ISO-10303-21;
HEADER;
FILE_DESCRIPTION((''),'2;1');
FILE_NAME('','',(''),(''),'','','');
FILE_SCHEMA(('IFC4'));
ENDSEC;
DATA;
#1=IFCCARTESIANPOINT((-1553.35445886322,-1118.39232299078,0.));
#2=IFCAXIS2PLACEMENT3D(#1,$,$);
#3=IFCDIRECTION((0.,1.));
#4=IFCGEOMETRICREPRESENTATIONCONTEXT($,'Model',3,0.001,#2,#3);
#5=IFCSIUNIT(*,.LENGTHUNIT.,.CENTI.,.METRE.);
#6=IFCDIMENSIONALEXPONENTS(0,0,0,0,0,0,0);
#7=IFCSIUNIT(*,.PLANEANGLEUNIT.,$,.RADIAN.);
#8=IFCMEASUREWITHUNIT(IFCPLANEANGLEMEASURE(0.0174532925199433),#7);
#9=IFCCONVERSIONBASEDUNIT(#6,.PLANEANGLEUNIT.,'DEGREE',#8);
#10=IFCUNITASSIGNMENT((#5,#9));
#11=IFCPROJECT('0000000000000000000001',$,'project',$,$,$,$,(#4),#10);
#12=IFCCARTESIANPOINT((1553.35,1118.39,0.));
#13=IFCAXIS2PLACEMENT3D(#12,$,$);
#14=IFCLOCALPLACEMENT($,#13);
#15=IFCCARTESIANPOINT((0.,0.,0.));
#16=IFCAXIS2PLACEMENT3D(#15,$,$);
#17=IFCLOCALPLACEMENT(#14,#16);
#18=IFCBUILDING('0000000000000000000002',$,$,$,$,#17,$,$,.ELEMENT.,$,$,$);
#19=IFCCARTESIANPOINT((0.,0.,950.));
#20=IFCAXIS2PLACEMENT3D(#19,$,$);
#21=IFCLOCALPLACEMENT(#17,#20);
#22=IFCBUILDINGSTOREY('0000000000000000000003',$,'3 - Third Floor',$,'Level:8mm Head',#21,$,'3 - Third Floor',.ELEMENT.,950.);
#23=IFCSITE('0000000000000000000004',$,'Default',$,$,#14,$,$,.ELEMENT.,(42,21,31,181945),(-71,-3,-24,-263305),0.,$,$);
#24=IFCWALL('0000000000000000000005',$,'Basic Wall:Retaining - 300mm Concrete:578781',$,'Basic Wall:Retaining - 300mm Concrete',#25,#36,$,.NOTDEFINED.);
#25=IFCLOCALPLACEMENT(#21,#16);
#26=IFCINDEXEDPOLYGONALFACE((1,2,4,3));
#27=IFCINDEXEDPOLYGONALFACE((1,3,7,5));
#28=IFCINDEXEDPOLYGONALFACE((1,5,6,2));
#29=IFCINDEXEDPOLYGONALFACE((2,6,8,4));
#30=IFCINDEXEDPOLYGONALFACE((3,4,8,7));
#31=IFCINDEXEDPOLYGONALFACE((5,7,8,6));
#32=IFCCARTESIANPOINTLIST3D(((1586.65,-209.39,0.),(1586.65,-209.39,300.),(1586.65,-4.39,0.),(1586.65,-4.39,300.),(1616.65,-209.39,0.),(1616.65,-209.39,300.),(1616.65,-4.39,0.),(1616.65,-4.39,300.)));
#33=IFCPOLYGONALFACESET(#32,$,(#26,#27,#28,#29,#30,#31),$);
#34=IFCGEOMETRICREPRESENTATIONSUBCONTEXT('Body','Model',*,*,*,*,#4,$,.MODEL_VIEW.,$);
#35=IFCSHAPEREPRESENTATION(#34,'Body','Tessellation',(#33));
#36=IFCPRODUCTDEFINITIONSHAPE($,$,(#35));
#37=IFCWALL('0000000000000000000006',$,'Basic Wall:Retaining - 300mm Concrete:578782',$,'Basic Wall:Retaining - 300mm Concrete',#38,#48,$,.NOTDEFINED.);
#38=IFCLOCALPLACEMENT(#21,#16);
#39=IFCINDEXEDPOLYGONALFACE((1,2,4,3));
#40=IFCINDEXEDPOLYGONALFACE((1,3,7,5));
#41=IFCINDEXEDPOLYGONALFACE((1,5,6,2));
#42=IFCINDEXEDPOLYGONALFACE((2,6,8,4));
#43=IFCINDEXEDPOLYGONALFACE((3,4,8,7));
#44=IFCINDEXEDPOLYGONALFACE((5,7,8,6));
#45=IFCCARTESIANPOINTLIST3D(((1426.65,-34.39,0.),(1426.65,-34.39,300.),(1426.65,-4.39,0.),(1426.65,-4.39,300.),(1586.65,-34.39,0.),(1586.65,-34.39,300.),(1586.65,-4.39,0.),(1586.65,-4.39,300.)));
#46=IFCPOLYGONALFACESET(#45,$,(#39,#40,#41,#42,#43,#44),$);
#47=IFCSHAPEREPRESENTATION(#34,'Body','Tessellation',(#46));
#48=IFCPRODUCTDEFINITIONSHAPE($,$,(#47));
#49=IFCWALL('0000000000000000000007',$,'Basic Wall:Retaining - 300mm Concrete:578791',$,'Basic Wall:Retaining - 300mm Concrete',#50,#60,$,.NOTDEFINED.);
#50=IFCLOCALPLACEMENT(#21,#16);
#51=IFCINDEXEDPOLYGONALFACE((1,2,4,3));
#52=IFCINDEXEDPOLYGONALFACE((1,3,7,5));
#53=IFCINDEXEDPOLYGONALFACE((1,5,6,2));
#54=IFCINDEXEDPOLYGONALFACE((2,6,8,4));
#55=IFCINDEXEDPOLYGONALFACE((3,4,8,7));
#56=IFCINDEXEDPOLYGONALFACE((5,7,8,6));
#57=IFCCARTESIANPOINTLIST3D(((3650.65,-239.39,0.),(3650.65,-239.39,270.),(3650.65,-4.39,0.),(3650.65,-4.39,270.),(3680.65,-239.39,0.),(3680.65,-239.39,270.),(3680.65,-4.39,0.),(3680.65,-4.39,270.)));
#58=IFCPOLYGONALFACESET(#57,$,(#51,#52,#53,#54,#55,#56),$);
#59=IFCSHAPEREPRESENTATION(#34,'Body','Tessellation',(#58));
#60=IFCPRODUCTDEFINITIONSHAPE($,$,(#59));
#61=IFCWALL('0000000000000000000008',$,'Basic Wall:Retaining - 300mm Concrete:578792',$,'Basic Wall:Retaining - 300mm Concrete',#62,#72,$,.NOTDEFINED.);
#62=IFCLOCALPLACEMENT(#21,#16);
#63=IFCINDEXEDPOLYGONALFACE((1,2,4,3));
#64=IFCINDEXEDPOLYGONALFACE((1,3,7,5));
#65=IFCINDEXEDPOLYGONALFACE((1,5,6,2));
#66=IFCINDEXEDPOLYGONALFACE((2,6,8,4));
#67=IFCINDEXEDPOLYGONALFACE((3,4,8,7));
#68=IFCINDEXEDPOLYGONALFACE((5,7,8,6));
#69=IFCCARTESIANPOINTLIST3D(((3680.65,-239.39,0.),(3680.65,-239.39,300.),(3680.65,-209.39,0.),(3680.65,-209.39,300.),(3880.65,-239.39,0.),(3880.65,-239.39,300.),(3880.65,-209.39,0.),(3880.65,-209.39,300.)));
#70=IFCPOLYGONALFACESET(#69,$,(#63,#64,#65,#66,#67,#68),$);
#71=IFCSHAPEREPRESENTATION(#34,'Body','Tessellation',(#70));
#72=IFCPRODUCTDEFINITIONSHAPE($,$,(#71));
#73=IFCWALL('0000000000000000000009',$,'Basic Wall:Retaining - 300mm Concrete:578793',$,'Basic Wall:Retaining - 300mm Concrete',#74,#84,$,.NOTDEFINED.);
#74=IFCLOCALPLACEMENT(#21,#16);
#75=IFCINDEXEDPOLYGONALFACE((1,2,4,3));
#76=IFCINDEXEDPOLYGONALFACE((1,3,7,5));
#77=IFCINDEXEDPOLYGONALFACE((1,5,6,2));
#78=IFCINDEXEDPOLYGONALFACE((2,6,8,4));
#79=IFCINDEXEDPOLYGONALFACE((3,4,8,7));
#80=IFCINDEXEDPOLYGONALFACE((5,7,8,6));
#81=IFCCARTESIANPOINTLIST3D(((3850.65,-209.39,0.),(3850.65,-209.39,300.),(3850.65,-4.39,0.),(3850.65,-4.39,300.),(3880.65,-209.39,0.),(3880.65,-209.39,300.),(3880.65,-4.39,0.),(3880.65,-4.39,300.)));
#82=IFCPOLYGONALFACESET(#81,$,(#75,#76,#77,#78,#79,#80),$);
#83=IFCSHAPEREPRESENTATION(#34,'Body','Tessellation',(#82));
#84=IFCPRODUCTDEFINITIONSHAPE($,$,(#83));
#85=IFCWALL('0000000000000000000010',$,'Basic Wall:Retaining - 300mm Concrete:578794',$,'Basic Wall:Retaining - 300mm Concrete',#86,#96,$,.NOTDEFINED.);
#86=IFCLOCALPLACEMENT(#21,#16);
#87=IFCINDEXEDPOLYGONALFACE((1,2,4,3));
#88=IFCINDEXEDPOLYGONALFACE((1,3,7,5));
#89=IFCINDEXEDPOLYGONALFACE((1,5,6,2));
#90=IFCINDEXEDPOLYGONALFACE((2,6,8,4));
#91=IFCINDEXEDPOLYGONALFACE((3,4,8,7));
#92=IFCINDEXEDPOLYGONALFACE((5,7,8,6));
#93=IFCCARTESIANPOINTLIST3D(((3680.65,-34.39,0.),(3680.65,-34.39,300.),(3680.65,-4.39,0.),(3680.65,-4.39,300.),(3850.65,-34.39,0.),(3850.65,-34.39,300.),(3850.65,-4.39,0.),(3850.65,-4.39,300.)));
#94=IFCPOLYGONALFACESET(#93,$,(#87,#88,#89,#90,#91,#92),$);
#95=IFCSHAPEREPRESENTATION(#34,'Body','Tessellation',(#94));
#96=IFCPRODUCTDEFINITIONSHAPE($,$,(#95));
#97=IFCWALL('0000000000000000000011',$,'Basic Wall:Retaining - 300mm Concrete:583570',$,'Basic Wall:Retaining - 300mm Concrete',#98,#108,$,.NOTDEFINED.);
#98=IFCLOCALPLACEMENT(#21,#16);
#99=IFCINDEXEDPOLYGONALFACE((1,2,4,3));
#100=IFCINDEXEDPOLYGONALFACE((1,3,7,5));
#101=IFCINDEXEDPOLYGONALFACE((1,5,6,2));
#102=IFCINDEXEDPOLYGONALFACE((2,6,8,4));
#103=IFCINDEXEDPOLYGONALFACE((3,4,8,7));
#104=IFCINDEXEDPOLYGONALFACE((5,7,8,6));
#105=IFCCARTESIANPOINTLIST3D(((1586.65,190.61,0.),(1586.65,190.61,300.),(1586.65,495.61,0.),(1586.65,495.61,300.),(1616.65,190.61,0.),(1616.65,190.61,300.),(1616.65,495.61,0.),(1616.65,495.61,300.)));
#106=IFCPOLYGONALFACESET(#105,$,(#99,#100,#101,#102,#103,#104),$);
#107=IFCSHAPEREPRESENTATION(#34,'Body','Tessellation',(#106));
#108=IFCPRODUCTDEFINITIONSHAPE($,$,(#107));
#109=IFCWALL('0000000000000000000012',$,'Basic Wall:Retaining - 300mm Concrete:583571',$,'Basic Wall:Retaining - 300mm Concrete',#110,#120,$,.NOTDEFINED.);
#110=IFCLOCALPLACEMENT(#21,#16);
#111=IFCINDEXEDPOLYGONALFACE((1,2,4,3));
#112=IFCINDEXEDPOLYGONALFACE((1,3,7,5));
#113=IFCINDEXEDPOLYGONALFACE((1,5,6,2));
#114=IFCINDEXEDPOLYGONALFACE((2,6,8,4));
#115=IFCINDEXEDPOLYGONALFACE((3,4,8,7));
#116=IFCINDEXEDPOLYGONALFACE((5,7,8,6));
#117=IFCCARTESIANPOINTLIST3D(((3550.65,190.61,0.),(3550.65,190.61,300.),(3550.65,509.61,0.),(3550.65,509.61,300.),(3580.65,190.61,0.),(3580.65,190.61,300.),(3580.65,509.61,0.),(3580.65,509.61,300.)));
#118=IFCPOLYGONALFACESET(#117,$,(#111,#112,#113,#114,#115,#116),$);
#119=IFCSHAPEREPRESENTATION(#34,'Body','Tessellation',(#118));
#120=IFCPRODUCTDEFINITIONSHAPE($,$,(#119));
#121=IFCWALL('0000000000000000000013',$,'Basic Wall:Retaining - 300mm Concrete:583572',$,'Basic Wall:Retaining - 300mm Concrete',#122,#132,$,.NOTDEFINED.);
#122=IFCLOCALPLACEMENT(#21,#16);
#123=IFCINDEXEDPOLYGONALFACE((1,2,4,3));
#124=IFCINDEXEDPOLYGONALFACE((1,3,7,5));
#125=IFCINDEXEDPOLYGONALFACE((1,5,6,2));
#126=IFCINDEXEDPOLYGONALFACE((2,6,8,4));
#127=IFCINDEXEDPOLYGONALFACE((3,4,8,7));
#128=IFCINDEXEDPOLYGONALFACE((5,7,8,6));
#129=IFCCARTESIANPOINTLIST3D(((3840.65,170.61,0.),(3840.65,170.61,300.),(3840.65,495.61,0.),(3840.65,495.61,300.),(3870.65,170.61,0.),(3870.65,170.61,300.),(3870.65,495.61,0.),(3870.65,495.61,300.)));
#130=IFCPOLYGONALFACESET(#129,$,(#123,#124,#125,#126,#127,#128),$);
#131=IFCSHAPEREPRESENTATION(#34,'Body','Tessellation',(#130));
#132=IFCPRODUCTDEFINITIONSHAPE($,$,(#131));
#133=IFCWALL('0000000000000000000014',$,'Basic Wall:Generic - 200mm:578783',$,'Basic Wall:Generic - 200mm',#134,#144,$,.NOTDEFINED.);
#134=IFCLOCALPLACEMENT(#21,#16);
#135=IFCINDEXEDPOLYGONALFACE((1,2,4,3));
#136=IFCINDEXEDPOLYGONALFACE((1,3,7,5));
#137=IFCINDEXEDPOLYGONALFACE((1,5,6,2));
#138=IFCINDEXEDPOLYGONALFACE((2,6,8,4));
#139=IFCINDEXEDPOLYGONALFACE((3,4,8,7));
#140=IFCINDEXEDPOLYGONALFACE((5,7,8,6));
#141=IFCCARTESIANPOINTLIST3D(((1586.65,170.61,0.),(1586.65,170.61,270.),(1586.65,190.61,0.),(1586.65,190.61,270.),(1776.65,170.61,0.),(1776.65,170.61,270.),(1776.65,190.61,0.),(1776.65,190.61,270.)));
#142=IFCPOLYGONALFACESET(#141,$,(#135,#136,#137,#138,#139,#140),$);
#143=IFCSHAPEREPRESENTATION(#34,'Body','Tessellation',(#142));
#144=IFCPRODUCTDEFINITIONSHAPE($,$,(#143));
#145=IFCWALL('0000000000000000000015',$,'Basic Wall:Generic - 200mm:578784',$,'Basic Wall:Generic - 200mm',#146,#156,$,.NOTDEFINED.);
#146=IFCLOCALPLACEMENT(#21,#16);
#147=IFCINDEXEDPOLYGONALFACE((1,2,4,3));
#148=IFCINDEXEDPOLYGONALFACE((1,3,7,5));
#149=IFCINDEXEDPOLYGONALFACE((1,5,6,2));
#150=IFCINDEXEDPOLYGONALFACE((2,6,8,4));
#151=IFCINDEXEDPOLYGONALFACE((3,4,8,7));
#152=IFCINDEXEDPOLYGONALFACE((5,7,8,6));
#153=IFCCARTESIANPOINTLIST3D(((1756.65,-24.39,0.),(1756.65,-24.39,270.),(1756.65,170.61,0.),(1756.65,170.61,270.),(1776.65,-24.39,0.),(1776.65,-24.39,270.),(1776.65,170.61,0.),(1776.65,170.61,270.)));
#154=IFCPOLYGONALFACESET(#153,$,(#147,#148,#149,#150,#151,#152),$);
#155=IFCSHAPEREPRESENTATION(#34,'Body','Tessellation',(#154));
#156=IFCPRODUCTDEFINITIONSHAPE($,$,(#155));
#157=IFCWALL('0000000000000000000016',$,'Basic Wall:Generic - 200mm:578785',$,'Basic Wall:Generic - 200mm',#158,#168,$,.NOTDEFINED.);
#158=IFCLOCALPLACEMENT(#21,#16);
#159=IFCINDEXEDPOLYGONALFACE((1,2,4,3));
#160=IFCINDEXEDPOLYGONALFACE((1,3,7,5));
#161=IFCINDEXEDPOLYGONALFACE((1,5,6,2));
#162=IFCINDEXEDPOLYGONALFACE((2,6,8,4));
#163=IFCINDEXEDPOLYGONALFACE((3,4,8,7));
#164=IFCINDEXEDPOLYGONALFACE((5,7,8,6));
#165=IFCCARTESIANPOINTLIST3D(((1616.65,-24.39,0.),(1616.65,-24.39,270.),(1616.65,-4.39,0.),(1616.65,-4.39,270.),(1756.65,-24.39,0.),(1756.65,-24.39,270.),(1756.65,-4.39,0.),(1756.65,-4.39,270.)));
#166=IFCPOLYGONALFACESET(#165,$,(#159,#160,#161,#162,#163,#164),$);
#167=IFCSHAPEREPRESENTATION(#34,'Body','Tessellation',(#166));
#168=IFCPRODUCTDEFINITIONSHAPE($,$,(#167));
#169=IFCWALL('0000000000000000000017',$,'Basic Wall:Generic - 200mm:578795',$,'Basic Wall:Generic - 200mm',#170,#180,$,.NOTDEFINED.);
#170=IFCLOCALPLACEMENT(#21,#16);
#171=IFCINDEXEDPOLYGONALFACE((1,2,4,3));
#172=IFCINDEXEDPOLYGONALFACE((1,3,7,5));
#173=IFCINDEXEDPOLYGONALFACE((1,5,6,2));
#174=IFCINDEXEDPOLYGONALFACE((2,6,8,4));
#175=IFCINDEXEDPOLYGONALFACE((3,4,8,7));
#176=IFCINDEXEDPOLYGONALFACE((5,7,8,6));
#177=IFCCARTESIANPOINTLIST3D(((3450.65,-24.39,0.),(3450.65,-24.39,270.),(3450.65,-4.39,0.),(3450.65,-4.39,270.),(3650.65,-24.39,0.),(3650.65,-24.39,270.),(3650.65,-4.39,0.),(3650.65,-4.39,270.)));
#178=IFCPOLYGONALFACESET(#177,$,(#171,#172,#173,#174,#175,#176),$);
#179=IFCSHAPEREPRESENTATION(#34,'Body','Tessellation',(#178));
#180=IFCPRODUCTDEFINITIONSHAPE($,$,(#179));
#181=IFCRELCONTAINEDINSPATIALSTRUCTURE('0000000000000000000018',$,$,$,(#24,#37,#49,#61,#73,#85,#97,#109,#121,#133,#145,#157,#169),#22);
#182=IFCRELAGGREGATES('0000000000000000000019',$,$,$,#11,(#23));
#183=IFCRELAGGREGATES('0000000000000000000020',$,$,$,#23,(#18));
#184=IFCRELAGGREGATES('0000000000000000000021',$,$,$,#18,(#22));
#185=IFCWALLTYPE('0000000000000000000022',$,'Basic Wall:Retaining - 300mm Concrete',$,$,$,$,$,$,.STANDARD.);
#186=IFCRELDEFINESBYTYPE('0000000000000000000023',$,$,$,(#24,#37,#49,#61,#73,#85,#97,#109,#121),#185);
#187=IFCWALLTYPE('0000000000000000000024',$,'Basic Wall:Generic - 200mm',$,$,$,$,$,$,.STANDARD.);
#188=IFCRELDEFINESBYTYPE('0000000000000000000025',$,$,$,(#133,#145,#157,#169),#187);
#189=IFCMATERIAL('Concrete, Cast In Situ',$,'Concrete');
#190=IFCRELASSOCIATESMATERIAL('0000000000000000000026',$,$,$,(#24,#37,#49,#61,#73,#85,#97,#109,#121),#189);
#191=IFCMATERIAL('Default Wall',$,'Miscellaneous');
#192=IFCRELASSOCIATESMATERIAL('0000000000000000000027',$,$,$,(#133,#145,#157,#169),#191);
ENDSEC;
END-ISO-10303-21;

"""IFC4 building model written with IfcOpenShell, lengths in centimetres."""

from ifc_helpers import new_model, entity, si_unit, converted_unit, direction, frame, origin, place, context, subcontext, project, spatial, indexed_curve, outline, extrude, material, type_object, element, save


model = new_model("IFC4")

# Units and contexts
model_context = context("Model", 3, precision=0.001, world=frame((-1553.35445886322, -1118.39232299078, 0.0)), true_north=direction((0.0, 1.0)))
body_context = subcontext(model_context, "Body", "Model", "MODEL_VIEW")
ifc_project = project(units=[si_unit("LENGTHUNIT", "METRE", prefix="CENTI"), converted_unit("PLANEANGLEUNIT", "DEGREE", entity("IfcPlaneAngleMeasure", 0.0174532925199433), si_unit("PLANEANGLEUNIT", "RADIAN"), dimensions=[0, 0, 0, 0, 0, 0, 0])], contexts=[model_context])

# Site, building, storey
site_placement = place(None, frame((1553.35, 1118.39, 0.0)))
site = spatial("IfcSite", under=ifc_project, at=site_placement, Name="Default", CompositionType="ELEMENT", RefLatitude=(42, 21, 31, 181945), RefLongitude=(-71, -3, -24, -263305), RefElevation=0.0)
building_placement = place(site_placement, origin())
building = spatial("IfcBuilding", under=site, at=building_placement, CompositionType="ELEMENT")
storey_placement = place(building_placement, frame((0.0, 0.0, 950.0)))
storey = spatial("IfcBuildingStorey", under=building, at=storey_placement, Name="3 - Third Floor", ObjectType="Level:8mm Head", LongName="3 - Third Floor", CompositionType="ELEMENT", Elevation=950.0)

# Walls
ifc_material_1 = material(Name="Concrete, Cast In Situ", Category="Concrete")
wall_type_1 = type_object("IfcWallType", Name="Basic Wall:Retaining - 300mm Concrete", PredefinedType="STANDARD")
wall_1_placement = place(storey_placement, frame((1601.65, -209.39, 0.0), z_axis=(0.0, 0.0, 1.0), x_axis=(0.0, 1.0, 0.0)))
element("IfcWall", 1, at=wall_1_placement, inside=storey, type_object=wall_type_1, material=ifc_material_1, Name="Basic Wall:Retaining - 300mm Concrete:578781", ObjectType="Basic Wall:Retaining - 300mm Concrete", PredefinedType="NOTDEFINED", context=body_context, shape_type="SweptSolid", body=[
    extrude(outline(indexed_curve([(205.0, 15.0), (0.0, 15.0), (0.0, -15.0), (205.0, -15.0), (205.0, 15.0)], self_intersect=False)), origin(), (0.0, 0.0, 1.0), 300.0),
])
wall_2_placement = place(storey_placement, frame((1586.65, -19.39, 0.0), z_axis=(0.0, 0.0, 1.0), x_axis=(-1.0, 0.0, 0.0)))
element("IfcWall", 2, at=wall_2_placement, inside=storey, type_object=wall_type_1, material=ifc_material_1, Name="Basic Wall:Retaining - 300mm Concrete:578782", ObjectType="Basic Wall:Retaining - 300mm Concrete", PredefinedType="NOTDEFINED", context=body_context, shape_type="SweptSolid", body=[
    extrude(outline(indexed_curve([(160.0, 15.0), (0.0, 15.0), (0.0, -15.0), (160.0, -15.0), (160.0, 15.0)], self_intersect=False)), origin(), (0.0, 0.0, 1.0), 300.0),
])
wall_3_placement = place(storey_placement, frame((3665.65, -4.39, 0.0), z_axis=(0.0, 0.0, 1.0), x_axis=(0.0, -1.0, 0.0)))
element("IfcWall", 3, at=wall_3_placement, inside=storey, type_object=wall_type_1, material=ifc_material_1, Name="Basic Wall:Retaining - 300mm Concrete:578791", ObjectType="Basic Wall:Retaining - 300mm Concrete", PredefinedType="NOTDEFINED", context=body_context, shape_type="SweptSolid", body=[
    extrude(outline(indexed_curve([(235.0, 15.0), (0.0, 15.0), (0.0, -15.0), (235.0, -15.0), (235.0, 15.0)], self_intersect=False)), origin(), (0.0, 0.0, 1.0), 270.0),
])
wall_4_placement = place(storey_placement, frame((3680.65, -224.39, 0.0)))
element("IfcWall", 4, at=wall_4_placement, inside=storey, type_object=wall_type_1, material=ifc_material_1, Name="Basic Wall:Retaining - 300mm Concrete:578792", ObjectType="Basic Wall:Retaining - 300mm Concrete", PredefinedType="NOTDEFINED", context=body_context, shape_type="SweptSolid", body=[
    extrude(outline(indexed_curve([(200.0, 15.0), (0.0, 15.0), (0.0, -15.0), (200.0, -15.0), (200.0, 15.0)], self_intersect=False)), origin(), (0.0, 0.0, 1.0), 300.0),
])
wall_5_placement = place(storey_placement, frame((3865.65, -209.39, 0.0), z_axis=(0.0, 0.0, 1.0), x_axis=(0.0, 1.0, 0.0)))
element("IfcWall", 5, at=wall_5_placement, inside=storey, type_object=wall_type_1, material=ifc_material_1, Name="Basic Wall:Retaining - 300mm Concrete:578793", ObjectType="Basic Wall:Retaining - 300mm Concrete", PredefinedType="NOTDEFINED", context=body_context, shape_type="SweptSolid", body=[
    extrude(outline(indexed_curve([(205.0, 15.0), (0.0, 15.0), (0.0, -15.0), (205.0, -15.0), (205.0, 15.0)], self_intersect=False)), origin(), (0.0, 0.0, 1.0), 300.0),
])
wall_6_placement = place(storey_placement, frame((3850.65, -19.39, 0.0), z_axis=(0.0, 0.0, 1.0), x_axis=(-1.0, 0.0, 0.0)))
element("IfcWall", 6, at=wall_6_placement, inside=storey, type_object=wall_type_1, material=ifc_material_1, Name="Basic Wall:Retaining - 300mm Concrete:578794", ObjectType="Basic Wall:Retaining - 300mm Concrete", PredefinedType="NOTDEFINED", context=body_context, shape_type="SweptSolid", body=[
    extrude(outline(indexed_curve([(170.0, 15.0), (0.0, 15.0), (0.0, -15.0), (170.0, -15.0), (170.0, 15.0)], self_intersect=False)), origin(), (0.0, 0.0, 1.0), 300.0),
])
wall_7_placement = place(storey_placement, frame((1601.65, 495.61, 0.0), z_axis=(0.0, 0.0, 1.0), x_axis=(0.0, -1.0, 0.0)))
element("IfcWall", 7, at=wall_7_placement, inside=storey, type_object=wall_type_1, material=ifc_material_1, Name="Basic Wall:Retaining - 300mm Concrete:583570", ObjectType="Basic Wall:Retaining - 300mm Concrete", PredefinedType="NOTDEFINED", context=body_context, shape_type="SweptSolid", body=[
    extrude(outline(indexed_curve([(305.0, 15.0), (0.0, 15.0), (0.0, -15.0), (305.0, -15.0), (305.0, 15.0)], self_intersect=False)), origin(), (0.0, 0.0, 1.0), 300.0),
])
wall_8_placement = place(storey_placement, frame((3565.65, 509.61, 0.0), z_axis=(0.0, 0.0, 1.0), x_axis=(0.0, -1.0, 0.0)))
element("IfcWall", 8, at=wall_8_placement, inside=storey, type_object=wall_type_1, material=ifc_material_1, Name="Basic Wall:Retaining - 300mm Concrete:583571", ObjectType="Basic Wall:Retaining - 300mm Concrete", PredefinedType="NOTDEFINED", context=body_context, shape_type="SweptSolid", body=[
    extrude(outline(indexed_curve([(319.0, 15.0), (0.0, 15.0), (0.0, -15.0), (319.0, -15.0), (319.0, 15.0)], self_intersect=False)), origin(), (0.0, 0.0, 1.0), 300.0),
])
wall_9_placement = place(storey_placement, frame((3855.65, 495.61, 0.0), z_axis=(0.0, 0.0, 1.0), x_axis=(0.0, -1.0, 0.0)))
element("IfcWall", 9, at=wall_9_placement, inside=storey, type_object=wall_type_1, material=ifc_material_1, Name="Basic Wall:Retaining - 300mm Concrete:583572", ObjectType="Basic Wall:Retaining - 300mm Concrete", PredefinedType="NOTDEFINED", context=body_context, shape_type="SweptSolid", body=[
    extrude(outline(indexed_curve([(325.0, 15.0), (0.0, 15.0), (0.0, -15.0), (325.0, -15.0), (325.0, 15.0)], self_intersect=False)), origin(), (0.0, 0.0, 1.0), 300.0),
])
ifc_material_2 = material(Name="Default Wall", Category="Miscellaneous")
wall_type_2 = type_object("IfcWallType", Name="Basic Wall:Generic - 200mm", PredefinedType="STANDARD")
wall_10_placement = place(storey_placement, frame((1586.65, 180.61, 0.0)))
element("IfcWall", 10, at=wall_10_placement, inside=storey, type_object=wall_type_2, material=ifc_material_2, Name="Basic Wall:Generic - 200mm:578783", ObjectType="Basic Wall:Generic - 200mm", PredefinedType="NOTDEFINED", context=body_context, shape_type="SweptSolid", body=[
    extrude(outline(indexed_curve([(190.0, 10.0), (0.0, 10.0), (0.0, -10.0), (190.0, -10.0), (190.0, 10.0)], self_intersect=False)), origin(), (0.0, 0.0, 1.0), 270.0),
])
wall_11_placement = place(storey_placement, frame((1766.65, 170.61, 0.0), z_axis=(0.0, 0.0, 1.0), x_axis=(0.0, -1.0, 0.0)))
element("IfcWall", 11, at=wall_11_placement, inside=storey, type_object=wall_type_2, material=ifc_material_2, Name="Basic Wall:Generic - 200mm:578784", ObjectType="Basic Wall:Generic - 200mm", PredefinedType="NOTDEFINED", context=body_context, shape_type="SweptSolid", body=[
    extrude(outline(indexed_curve([(195.0, 10.0), (0.0, 10.0), (0.0, -10.0), (195.0, -10.0), (195.0, 10.0)], self_intersect=False)), origin(), (0.0, 0.0, 1.0), 270.0),
])
wall_12_placement = place(storey_placement, frame((1616.65, -14.39, 0.0)))
element("IfcWall", 12, at=wall_12_placement, inside=storey, type_object=wall_type_2, material=ifc_material_2, Name="Basic Wall:Generic - 200mm:578785", ObjectType="Basic Wall:Generic - 200mm", PredefinedType="NOTDEFINED", context=body_context, shape_type="SweptSolid", body=[
    extrude(outline(indexed_curve([(140.0, 10.0), (0.0, 10.0), (0.0, -10.0), (140.0, -10.0), (140.0, 10.0)], self_intersect=False)), origin(), (0.0, 0.0, 1.0), 270.0),
])
wall_13_placement = place(storey_placement, frame((3650.65, -14.39, 0.0), z_axis=(0.0, 0.0, 1.0), x_axis=(-1.0, 0.0, 0.0)))
element("IfcWall", 13, at=wall_13_placement, inside=storey, type_object=wall_type_2, material=ifc_material_2, Name="Basic Wall:Generic - 200mm:578795", ObjectType="Basic Wall:Generic - 200mm", PredefinedType="NOTDEFINED", context=body_context, shape_type="SweptSolid", body=[
    extrude(outline(indexed_curve([(200.0, 10.0), (0.0, 10.0), (0.0, -10.0), (200.0, -10.0), (200.0, 10.0)], self_intersect=False)), origin(), (0.0, 0.0, 1.0), 270.0),
])

save(model, "model.ifc")
